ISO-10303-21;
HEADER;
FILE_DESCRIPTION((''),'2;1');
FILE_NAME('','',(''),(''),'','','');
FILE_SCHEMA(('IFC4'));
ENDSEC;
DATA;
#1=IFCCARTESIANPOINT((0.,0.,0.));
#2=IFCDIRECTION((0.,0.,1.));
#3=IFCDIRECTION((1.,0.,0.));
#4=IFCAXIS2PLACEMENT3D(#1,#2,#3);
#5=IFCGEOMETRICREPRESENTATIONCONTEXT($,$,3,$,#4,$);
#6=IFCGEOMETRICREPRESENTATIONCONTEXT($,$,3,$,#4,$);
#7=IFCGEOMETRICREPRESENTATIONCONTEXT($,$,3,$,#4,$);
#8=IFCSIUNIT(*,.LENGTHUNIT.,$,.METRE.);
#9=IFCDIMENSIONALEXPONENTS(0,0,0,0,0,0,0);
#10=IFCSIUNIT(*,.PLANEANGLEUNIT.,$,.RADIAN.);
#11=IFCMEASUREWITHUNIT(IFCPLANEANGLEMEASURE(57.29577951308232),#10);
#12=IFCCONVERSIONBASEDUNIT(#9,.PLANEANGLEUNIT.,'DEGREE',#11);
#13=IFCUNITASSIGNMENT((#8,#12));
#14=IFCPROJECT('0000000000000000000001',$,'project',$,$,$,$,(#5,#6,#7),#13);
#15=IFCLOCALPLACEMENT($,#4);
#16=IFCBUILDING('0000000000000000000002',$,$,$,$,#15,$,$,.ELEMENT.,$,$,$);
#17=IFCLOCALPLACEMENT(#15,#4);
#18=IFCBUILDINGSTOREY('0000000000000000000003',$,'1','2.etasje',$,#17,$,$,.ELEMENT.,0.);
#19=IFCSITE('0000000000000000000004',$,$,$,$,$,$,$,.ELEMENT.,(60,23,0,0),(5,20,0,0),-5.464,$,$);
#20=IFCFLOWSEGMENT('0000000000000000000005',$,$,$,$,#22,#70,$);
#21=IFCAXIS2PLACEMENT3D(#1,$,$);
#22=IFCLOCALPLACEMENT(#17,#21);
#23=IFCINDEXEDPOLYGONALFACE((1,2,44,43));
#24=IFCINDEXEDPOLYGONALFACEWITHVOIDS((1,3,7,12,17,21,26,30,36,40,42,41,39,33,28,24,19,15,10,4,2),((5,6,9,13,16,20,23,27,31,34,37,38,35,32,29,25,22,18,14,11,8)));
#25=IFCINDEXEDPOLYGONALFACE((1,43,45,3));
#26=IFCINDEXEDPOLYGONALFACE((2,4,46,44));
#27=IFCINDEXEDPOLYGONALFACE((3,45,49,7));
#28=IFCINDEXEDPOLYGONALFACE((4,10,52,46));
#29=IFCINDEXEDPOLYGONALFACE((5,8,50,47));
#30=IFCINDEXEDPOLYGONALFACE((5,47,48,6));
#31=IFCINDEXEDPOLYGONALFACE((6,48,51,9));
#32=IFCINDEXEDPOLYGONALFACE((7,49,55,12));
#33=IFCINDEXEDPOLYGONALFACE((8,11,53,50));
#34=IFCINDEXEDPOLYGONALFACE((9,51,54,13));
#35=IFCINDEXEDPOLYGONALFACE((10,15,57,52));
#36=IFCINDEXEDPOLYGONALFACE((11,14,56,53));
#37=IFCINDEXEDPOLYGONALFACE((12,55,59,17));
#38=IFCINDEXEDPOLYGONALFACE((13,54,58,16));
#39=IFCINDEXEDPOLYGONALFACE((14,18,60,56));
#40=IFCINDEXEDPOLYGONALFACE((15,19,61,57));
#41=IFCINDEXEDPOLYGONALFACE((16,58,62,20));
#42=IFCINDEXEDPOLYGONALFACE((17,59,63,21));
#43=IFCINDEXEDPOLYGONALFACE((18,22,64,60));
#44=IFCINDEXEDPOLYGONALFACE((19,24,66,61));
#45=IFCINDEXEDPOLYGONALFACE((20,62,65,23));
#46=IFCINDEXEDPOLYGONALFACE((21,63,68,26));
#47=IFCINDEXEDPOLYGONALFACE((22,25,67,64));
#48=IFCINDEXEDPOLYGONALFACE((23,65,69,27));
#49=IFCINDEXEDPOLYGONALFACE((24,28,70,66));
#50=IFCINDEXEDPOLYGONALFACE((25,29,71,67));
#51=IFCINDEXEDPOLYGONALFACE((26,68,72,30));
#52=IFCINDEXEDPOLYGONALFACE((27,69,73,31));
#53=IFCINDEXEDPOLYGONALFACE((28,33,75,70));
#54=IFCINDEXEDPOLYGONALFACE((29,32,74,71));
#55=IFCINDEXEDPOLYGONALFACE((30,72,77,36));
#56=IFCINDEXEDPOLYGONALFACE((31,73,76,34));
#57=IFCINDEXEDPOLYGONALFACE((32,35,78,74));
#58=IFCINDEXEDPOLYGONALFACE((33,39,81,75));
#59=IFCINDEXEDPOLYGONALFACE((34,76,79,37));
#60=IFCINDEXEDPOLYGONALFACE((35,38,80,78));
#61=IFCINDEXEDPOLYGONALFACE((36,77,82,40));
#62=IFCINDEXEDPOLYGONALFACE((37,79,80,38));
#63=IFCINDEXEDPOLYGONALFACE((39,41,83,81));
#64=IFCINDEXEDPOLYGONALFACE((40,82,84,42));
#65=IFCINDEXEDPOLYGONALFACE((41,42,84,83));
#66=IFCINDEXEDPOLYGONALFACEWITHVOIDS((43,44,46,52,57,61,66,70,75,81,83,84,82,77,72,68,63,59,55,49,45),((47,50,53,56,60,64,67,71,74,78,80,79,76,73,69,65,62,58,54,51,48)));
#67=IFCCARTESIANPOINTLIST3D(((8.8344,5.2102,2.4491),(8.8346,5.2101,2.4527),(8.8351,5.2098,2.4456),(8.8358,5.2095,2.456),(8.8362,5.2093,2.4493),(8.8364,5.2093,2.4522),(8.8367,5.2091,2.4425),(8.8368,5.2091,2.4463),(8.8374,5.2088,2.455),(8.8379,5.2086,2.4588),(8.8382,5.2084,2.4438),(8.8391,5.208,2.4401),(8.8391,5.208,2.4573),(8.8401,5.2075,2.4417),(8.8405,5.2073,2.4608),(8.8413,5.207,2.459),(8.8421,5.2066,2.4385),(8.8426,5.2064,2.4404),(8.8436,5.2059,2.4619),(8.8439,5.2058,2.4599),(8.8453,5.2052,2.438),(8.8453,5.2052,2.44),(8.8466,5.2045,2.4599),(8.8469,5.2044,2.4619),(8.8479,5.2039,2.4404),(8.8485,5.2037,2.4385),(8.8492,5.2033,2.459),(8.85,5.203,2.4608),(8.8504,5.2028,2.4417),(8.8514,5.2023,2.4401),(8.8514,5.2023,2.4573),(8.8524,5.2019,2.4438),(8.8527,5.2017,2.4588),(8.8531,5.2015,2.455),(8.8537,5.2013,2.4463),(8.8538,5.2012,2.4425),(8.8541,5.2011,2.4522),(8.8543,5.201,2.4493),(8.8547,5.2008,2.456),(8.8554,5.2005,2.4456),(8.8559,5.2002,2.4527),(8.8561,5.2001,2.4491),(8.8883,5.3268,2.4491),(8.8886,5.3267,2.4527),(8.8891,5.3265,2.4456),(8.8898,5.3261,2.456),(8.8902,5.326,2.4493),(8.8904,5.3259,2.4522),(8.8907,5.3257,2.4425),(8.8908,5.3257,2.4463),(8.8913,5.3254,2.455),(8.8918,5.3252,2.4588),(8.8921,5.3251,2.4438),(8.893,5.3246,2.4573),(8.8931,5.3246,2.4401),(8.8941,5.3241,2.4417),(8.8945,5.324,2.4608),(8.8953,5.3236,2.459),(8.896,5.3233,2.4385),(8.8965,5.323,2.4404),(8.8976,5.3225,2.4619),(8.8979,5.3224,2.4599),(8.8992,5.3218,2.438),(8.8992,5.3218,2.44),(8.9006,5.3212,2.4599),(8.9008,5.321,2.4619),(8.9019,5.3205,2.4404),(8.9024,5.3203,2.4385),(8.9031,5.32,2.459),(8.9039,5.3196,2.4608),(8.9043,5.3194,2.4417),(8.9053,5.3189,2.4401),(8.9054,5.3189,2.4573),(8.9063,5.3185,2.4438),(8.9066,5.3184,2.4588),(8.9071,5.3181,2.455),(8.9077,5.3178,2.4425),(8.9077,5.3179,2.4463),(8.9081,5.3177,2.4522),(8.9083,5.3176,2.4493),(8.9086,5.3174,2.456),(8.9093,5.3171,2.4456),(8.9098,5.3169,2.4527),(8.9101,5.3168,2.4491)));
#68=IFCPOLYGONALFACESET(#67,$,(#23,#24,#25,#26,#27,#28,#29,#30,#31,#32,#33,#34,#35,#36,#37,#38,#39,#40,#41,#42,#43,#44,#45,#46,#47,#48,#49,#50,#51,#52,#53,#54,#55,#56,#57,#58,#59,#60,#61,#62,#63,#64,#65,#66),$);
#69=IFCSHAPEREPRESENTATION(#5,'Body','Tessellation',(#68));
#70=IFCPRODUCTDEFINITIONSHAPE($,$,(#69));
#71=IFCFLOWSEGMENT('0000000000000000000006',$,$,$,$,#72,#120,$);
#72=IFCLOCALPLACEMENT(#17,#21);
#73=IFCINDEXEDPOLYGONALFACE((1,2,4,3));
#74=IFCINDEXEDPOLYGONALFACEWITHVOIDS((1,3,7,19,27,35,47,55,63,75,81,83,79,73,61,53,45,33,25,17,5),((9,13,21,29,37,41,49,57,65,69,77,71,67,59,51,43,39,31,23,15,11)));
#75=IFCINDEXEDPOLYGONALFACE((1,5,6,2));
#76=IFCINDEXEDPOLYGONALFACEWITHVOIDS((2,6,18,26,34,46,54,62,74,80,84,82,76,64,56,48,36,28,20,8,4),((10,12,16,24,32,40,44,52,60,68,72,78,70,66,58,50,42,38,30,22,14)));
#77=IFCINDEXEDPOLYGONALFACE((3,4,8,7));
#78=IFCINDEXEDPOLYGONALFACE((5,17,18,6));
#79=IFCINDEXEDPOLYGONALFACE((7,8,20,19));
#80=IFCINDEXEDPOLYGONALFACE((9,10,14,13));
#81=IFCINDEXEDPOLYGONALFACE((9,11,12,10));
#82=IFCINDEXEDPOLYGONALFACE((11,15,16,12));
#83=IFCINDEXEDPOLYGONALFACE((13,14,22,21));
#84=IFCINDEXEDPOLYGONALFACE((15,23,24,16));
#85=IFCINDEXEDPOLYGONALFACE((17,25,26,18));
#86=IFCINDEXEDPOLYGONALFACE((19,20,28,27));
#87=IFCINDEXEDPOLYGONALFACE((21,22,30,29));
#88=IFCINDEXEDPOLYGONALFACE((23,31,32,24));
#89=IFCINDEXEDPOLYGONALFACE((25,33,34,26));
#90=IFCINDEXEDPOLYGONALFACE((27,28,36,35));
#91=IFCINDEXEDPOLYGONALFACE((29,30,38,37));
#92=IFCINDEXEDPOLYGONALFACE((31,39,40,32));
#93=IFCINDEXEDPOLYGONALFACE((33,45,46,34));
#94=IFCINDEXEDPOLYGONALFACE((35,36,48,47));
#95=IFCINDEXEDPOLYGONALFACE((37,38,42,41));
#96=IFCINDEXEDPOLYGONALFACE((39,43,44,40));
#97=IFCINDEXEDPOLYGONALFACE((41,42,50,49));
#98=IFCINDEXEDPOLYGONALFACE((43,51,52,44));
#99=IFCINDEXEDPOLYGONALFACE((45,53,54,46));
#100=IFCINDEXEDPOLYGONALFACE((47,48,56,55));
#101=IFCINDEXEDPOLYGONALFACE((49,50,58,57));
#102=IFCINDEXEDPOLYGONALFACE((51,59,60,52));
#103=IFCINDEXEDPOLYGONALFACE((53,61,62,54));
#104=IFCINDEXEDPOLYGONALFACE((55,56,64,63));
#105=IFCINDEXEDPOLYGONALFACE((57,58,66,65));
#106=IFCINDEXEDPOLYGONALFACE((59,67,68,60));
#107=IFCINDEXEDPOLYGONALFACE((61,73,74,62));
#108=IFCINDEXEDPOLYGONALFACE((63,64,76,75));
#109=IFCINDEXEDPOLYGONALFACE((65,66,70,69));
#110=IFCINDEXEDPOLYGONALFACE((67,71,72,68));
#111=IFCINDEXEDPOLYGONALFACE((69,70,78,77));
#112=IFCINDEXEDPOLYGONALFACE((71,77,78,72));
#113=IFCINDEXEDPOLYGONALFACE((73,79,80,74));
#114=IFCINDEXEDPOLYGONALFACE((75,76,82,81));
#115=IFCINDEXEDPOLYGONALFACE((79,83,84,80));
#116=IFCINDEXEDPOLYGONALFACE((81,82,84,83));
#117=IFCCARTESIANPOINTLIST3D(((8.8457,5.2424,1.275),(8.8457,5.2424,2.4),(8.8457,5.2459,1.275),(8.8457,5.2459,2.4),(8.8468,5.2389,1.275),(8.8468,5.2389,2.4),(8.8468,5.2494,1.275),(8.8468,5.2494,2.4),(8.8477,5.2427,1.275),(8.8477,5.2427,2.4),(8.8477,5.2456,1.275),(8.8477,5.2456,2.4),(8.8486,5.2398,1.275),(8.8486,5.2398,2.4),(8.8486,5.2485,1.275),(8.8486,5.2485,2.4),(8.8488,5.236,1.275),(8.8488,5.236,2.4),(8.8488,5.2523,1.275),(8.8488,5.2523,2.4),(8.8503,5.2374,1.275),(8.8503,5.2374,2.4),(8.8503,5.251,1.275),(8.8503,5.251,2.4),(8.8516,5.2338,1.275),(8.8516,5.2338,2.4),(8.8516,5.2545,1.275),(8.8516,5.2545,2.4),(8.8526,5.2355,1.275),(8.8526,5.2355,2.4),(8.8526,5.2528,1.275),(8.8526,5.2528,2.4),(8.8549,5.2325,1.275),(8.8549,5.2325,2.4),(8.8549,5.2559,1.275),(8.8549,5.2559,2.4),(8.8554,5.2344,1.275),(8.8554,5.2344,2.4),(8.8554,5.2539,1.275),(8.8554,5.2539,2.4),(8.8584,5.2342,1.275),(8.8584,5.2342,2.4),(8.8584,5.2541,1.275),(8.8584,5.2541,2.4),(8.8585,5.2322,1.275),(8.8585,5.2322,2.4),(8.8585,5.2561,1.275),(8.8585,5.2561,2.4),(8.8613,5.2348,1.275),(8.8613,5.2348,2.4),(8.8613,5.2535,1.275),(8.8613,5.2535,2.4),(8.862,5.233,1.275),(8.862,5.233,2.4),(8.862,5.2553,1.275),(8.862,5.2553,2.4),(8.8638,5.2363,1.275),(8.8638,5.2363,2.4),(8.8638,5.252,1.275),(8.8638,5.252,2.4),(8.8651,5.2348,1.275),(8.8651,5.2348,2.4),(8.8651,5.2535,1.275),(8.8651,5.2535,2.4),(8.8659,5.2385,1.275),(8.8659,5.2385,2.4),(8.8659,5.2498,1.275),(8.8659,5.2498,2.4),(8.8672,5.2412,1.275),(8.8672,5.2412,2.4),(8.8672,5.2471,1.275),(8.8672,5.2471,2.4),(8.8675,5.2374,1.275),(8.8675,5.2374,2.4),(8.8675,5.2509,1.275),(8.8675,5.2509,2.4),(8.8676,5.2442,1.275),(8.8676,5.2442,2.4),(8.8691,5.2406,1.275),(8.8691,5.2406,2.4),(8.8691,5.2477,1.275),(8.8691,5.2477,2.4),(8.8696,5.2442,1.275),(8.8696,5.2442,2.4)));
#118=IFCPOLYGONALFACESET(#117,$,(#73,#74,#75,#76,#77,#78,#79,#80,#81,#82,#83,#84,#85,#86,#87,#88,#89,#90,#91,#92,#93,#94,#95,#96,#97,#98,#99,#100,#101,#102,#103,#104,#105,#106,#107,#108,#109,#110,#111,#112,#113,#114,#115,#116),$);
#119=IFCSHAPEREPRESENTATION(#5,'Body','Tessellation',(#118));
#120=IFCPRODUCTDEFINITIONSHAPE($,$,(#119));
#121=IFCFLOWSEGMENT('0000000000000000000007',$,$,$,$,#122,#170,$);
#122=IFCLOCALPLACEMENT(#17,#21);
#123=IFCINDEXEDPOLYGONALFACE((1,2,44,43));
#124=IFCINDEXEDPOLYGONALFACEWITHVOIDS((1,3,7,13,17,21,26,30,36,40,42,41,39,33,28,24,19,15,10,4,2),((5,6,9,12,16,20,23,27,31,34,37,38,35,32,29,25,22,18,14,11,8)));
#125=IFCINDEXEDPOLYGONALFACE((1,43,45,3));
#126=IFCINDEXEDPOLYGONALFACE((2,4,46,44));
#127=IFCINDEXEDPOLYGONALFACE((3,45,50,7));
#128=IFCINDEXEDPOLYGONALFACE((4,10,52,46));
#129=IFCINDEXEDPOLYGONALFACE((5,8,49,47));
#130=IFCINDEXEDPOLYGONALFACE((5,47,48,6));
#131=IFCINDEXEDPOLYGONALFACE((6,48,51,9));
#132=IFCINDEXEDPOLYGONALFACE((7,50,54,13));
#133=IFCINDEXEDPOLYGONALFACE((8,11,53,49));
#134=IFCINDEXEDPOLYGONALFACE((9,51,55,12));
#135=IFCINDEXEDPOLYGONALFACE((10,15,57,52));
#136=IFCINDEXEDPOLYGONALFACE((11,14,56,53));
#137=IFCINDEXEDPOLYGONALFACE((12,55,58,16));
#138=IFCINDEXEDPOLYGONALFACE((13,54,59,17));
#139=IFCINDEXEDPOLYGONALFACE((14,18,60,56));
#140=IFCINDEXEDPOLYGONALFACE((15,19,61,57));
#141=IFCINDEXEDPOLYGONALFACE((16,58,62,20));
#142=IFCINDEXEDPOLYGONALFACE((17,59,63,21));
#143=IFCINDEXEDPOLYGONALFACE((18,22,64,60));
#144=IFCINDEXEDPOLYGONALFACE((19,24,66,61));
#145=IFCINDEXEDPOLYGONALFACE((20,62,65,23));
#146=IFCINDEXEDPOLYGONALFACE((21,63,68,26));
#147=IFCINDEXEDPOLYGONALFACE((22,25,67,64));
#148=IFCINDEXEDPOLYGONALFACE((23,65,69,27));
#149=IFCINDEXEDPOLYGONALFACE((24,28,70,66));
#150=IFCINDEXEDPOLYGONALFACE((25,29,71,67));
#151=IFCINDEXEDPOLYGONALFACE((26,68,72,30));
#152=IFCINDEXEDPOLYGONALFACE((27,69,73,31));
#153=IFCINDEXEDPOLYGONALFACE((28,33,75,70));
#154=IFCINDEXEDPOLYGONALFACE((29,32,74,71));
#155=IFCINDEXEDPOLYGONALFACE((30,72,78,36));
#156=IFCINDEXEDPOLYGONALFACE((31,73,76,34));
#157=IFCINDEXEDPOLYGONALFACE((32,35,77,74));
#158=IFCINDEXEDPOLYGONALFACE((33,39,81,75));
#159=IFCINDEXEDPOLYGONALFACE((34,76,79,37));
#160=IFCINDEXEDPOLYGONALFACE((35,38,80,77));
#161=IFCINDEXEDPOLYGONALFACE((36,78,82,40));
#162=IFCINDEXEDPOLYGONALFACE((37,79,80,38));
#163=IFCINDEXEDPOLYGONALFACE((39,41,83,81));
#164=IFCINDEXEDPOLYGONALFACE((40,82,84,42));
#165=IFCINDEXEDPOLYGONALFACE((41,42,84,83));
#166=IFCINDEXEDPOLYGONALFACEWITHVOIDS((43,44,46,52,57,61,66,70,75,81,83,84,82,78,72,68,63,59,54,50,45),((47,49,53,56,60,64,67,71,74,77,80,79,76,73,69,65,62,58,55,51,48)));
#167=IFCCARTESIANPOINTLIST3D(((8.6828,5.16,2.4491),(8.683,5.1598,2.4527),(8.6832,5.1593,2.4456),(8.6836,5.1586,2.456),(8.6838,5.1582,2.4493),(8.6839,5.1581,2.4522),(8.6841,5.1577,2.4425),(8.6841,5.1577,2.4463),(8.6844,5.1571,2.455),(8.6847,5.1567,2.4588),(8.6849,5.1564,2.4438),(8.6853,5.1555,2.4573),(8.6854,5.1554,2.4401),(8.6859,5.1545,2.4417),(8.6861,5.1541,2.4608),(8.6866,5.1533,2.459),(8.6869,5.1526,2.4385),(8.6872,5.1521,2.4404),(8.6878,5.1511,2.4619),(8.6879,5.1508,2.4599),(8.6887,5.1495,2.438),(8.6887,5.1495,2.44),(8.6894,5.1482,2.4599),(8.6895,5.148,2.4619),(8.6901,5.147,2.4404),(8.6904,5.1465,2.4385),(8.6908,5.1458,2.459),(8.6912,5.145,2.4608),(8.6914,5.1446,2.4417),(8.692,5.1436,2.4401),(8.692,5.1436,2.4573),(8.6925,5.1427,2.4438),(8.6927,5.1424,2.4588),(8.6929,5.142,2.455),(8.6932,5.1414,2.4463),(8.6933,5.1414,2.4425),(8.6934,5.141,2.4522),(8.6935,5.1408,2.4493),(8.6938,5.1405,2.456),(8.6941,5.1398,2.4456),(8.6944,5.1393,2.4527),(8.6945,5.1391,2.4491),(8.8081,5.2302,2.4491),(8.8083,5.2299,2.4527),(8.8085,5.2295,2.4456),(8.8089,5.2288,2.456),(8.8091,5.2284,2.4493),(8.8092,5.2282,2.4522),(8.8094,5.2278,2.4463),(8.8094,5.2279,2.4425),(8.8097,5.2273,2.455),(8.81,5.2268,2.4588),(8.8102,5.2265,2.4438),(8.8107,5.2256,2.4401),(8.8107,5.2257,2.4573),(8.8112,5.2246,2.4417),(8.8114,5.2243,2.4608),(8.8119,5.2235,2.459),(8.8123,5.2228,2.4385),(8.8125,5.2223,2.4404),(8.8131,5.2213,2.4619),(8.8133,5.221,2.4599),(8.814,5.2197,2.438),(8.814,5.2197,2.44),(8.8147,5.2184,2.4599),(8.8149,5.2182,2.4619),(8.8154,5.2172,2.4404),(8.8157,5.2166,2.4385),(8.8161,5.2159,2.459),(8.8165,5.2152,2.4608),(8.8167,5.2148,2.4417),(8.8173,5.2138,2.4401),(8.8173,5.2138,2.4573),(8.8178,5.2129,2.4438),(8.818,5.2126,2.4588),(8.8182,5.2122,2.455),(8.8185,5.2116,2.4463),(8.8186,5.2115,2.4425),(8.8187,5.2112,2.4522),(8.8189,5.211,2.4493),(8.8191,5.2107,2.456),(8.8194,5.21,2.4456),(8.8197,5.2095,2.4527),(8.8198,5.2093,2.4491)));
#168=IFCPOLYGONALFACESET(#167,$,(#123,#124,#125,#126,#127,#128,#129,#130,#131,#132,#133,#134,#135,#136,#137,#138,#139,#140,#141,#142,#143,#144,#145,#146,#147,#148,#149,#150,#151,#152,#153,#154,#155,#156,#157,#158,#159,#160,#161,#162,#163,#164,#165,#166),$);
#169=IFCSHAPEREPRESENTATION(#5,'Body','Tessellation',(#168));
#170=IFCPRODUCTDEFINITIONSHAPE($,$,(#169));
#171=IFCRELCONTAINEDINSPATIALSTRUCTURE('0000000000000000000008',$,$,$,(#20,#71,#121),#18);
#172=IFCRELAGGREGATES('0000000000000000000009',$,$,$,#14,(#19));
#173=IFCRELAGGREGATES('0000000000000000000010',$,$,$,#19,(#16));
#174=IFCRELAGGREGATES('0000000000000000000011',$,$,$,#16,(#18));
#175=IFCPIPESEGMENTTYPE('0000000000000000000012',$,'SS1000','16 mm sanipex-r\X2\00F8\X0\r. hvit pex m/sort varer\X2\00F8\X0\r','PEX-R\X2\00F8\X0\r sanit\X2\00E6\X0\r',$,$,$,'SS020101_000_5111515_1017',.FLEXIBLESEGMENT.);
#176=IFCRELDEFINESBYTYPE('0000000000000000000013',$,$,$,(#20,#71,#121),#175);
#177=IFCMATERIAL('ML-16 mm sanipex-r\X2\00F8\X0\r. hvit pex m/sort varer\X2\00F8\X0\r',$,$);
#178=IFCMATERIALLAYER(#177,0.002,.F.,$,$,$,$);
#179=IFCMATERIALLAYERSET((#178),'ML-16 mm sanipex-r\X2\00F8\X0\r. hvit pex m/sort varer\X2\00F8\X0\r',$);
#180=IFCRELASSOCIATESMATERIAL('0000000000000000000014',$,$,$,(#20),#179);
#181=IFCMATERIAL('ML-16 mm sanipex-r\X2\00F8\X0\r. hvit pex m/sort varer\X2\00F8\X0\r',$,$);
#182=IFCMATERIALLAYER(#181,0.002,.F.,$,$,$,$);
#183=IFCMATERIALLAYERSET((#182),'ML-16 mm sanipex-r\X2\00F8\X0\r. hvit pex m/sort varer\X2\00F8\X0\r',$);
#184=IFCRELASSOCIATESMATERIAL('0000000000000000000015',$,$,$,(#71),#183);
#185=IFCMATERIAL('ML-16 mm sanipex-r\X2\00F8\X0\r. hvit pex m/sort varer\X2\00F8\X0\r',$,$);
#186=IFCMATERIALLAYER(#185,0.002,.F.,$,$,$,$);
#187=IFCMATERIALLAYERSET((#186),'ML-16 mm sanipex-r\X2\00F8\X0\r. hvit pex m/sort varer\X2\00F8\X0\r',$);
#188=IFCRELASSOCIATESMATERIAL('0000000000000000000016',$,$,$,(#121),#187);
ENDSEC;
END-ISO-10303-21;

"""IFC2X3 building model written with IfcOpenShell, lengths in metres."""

from ifc_helpers import new_model, entity, si_unit, converted_unit, frame, origin_with_axes, origin_2d_with_axis, place, context, project, spatial, hollow_circle, extrude, material, layer, layer_set, layer_usage, type_object, element, save


model = new_model("IFC2X3")

# Units and contexts
context_of_model_1 = context(None, 3, world=origin_with_axes())
context_of_model_2 = context(None, 3, world=origin_with_axes())
context_of_model_3 = context(None, 3, world=origin_with_axes())
ifc_project = project(units=[si_unit("LENGTHUNIT", "METRE"), converted_unit("PLANEANGLEUNIT", "DEGREE", entity("IfcPlaneAngleMeasure", 57.29577951308232), si_unit("PLANEANGLEUNIT", "RADIAN"), dimensions=[0, 0, 0, 0, 0, 0, 0])], contexts=[context_of_model_1, context_of_model_2, context_of_model_3])

# Site, building, storey
site = spatial("IfcSite", under=ifc_project, CompositionType="ELEMENT", RefLatitude=(60, 23, 0, 0), RefLongitude=(5, 20, 0, 0), RefElevation=-5.464)
building_placement = place(None, origin_with_axes())
building = spatial("IfcBuilding", under=site, at=building_placement, CompositionType="ELEMENT")
storey_placement = place(building_placement, origin_with_axes())
storey = spatial("IfcBuildingStorey", under=building, at=storey_placement, Name="1", Description="2.etasje", CompositionType="ELEMENT", Elevation=0.0)

# Flow segments
pipe_segment_type_1 = type_object("IfcPipeSegmentType", Name="SS1000", Description="16 mm sanipex-rør. hvit pex m/sort varerør", ApplicableOccurrence="PEX-Rør sanitær", ElementType="SS020101_000_5111515_1017", PredefinedType="FLEXIBLESEGMENT")
ifc_material_1 = material(Name="ML-16 mm sanipex-rør. hvit pex m/sort varerør")
ifc_layer_1 = layer(ifc_material_1, 0.002, ventilated=False)
ifc_layer_set_1 = layer_set([ifc_layer_1], Name="ML-16 mm sanipex-rør. hvit pex m/sort varerør")
ifc_layer_usage_1 = layer_usage(ifc_layer_set_1, "AXIS2", "POSITIVE", 0.0)
flow_segment_1_placement = place(storey_placement, frame((8.8453, 5.2052, 2.45), z_axis=(0.419822, 0.907607, 0.0), x_axis=(0.0, 0.0, -1.0)))
element("IfcFlowSegment", 1, at=flow_segment_1_placement, inside=storey, type_object=pipe_segment_type_1, material=ifc_layer_usage_1, context=context_of_model_1, shape_type="SweptSolid", body=[
    extrude(hollow_circle(Radius=0.012, WallThickness=0.002, at=origin_2d_with_axis()), origin_with_axes(), (0.0, 0.0, 1.0), 0.1285),
])
ifc_material_2 = material(Name="ML-16 mm sanipex-rør. hvit pex m/sort varerør")
ifc_layer_2 = layer(ifc_material_2, 0.002, ventilated=False)
ifc_layer_set_2 = layer_set([ifc_layer_2], Name="ML-16 mm sanipex-rør. hvit pex m/sort varerør")
ifc_layer_usage_2 = layer_usage(ifc_layer_set_2, "AXIS2", "POSITIVE", 0.0)
flow_segment_2_placement = place(storey_placement, frame((8.8576, 5.2442, 1.275), z_axis=(0.0, 0.0, 1.0), x_axis=(1.0, 0.0, 0.0)))
element("IfcFlowSegment", 2, at=flow_segment_2_placement, inside=storey, type_object=pipe_segment_type_1, material=ifc_layer_usage_2, context=context_of_model_1, shape_type="SweptSolid", body=[
    extrude(hollow_circle(Radius=0.012, WallThickness=0.002, at=origin_2d_with_axis()), origin_with_axes(), (0.0, 0.0, 1.0), 1.125),
])
ifc_material_3 = material(Name="ML-16 mm sanipex-rør. hvit pex m/sort varerør")
ifc_layer_3 = layer(ifc_material_3, 0.002, ventilated=False)
ifc_layer_set_3 = layer_set([ifc_layer_3], Name="ML-16 mm sanipex-rør. hvit pex m/sort varerør")
ifc_layer_usage_3 = layer_usage(ifc_layer_set_3, "AXIS2", "POSITIVE", 0.0)
flow_segment_3_placement = place(storey_placement, frame((8.814, 5.2197, 2.45), z_axis=(-0.872485, -0.488642, 0.0), x_axis=(0.0, 0.0, -1.0)))
element("IfcFlowSegment", 3, at=flow_segment_3_placement, inside=storey, type_object=pipe_segment_type_1, material=ifc_layer_usage_3, context=context_of_model_1, shape_type="SweptSolid", body=[
    extrude(hollow_circle(Radius=0.012, WallThickness=0.002, at=origin_2d_with_axis()), origin_with_axes(), (0.0, 0.0, 1.0), 0.1436),
])

save(model, "model.ifc")
